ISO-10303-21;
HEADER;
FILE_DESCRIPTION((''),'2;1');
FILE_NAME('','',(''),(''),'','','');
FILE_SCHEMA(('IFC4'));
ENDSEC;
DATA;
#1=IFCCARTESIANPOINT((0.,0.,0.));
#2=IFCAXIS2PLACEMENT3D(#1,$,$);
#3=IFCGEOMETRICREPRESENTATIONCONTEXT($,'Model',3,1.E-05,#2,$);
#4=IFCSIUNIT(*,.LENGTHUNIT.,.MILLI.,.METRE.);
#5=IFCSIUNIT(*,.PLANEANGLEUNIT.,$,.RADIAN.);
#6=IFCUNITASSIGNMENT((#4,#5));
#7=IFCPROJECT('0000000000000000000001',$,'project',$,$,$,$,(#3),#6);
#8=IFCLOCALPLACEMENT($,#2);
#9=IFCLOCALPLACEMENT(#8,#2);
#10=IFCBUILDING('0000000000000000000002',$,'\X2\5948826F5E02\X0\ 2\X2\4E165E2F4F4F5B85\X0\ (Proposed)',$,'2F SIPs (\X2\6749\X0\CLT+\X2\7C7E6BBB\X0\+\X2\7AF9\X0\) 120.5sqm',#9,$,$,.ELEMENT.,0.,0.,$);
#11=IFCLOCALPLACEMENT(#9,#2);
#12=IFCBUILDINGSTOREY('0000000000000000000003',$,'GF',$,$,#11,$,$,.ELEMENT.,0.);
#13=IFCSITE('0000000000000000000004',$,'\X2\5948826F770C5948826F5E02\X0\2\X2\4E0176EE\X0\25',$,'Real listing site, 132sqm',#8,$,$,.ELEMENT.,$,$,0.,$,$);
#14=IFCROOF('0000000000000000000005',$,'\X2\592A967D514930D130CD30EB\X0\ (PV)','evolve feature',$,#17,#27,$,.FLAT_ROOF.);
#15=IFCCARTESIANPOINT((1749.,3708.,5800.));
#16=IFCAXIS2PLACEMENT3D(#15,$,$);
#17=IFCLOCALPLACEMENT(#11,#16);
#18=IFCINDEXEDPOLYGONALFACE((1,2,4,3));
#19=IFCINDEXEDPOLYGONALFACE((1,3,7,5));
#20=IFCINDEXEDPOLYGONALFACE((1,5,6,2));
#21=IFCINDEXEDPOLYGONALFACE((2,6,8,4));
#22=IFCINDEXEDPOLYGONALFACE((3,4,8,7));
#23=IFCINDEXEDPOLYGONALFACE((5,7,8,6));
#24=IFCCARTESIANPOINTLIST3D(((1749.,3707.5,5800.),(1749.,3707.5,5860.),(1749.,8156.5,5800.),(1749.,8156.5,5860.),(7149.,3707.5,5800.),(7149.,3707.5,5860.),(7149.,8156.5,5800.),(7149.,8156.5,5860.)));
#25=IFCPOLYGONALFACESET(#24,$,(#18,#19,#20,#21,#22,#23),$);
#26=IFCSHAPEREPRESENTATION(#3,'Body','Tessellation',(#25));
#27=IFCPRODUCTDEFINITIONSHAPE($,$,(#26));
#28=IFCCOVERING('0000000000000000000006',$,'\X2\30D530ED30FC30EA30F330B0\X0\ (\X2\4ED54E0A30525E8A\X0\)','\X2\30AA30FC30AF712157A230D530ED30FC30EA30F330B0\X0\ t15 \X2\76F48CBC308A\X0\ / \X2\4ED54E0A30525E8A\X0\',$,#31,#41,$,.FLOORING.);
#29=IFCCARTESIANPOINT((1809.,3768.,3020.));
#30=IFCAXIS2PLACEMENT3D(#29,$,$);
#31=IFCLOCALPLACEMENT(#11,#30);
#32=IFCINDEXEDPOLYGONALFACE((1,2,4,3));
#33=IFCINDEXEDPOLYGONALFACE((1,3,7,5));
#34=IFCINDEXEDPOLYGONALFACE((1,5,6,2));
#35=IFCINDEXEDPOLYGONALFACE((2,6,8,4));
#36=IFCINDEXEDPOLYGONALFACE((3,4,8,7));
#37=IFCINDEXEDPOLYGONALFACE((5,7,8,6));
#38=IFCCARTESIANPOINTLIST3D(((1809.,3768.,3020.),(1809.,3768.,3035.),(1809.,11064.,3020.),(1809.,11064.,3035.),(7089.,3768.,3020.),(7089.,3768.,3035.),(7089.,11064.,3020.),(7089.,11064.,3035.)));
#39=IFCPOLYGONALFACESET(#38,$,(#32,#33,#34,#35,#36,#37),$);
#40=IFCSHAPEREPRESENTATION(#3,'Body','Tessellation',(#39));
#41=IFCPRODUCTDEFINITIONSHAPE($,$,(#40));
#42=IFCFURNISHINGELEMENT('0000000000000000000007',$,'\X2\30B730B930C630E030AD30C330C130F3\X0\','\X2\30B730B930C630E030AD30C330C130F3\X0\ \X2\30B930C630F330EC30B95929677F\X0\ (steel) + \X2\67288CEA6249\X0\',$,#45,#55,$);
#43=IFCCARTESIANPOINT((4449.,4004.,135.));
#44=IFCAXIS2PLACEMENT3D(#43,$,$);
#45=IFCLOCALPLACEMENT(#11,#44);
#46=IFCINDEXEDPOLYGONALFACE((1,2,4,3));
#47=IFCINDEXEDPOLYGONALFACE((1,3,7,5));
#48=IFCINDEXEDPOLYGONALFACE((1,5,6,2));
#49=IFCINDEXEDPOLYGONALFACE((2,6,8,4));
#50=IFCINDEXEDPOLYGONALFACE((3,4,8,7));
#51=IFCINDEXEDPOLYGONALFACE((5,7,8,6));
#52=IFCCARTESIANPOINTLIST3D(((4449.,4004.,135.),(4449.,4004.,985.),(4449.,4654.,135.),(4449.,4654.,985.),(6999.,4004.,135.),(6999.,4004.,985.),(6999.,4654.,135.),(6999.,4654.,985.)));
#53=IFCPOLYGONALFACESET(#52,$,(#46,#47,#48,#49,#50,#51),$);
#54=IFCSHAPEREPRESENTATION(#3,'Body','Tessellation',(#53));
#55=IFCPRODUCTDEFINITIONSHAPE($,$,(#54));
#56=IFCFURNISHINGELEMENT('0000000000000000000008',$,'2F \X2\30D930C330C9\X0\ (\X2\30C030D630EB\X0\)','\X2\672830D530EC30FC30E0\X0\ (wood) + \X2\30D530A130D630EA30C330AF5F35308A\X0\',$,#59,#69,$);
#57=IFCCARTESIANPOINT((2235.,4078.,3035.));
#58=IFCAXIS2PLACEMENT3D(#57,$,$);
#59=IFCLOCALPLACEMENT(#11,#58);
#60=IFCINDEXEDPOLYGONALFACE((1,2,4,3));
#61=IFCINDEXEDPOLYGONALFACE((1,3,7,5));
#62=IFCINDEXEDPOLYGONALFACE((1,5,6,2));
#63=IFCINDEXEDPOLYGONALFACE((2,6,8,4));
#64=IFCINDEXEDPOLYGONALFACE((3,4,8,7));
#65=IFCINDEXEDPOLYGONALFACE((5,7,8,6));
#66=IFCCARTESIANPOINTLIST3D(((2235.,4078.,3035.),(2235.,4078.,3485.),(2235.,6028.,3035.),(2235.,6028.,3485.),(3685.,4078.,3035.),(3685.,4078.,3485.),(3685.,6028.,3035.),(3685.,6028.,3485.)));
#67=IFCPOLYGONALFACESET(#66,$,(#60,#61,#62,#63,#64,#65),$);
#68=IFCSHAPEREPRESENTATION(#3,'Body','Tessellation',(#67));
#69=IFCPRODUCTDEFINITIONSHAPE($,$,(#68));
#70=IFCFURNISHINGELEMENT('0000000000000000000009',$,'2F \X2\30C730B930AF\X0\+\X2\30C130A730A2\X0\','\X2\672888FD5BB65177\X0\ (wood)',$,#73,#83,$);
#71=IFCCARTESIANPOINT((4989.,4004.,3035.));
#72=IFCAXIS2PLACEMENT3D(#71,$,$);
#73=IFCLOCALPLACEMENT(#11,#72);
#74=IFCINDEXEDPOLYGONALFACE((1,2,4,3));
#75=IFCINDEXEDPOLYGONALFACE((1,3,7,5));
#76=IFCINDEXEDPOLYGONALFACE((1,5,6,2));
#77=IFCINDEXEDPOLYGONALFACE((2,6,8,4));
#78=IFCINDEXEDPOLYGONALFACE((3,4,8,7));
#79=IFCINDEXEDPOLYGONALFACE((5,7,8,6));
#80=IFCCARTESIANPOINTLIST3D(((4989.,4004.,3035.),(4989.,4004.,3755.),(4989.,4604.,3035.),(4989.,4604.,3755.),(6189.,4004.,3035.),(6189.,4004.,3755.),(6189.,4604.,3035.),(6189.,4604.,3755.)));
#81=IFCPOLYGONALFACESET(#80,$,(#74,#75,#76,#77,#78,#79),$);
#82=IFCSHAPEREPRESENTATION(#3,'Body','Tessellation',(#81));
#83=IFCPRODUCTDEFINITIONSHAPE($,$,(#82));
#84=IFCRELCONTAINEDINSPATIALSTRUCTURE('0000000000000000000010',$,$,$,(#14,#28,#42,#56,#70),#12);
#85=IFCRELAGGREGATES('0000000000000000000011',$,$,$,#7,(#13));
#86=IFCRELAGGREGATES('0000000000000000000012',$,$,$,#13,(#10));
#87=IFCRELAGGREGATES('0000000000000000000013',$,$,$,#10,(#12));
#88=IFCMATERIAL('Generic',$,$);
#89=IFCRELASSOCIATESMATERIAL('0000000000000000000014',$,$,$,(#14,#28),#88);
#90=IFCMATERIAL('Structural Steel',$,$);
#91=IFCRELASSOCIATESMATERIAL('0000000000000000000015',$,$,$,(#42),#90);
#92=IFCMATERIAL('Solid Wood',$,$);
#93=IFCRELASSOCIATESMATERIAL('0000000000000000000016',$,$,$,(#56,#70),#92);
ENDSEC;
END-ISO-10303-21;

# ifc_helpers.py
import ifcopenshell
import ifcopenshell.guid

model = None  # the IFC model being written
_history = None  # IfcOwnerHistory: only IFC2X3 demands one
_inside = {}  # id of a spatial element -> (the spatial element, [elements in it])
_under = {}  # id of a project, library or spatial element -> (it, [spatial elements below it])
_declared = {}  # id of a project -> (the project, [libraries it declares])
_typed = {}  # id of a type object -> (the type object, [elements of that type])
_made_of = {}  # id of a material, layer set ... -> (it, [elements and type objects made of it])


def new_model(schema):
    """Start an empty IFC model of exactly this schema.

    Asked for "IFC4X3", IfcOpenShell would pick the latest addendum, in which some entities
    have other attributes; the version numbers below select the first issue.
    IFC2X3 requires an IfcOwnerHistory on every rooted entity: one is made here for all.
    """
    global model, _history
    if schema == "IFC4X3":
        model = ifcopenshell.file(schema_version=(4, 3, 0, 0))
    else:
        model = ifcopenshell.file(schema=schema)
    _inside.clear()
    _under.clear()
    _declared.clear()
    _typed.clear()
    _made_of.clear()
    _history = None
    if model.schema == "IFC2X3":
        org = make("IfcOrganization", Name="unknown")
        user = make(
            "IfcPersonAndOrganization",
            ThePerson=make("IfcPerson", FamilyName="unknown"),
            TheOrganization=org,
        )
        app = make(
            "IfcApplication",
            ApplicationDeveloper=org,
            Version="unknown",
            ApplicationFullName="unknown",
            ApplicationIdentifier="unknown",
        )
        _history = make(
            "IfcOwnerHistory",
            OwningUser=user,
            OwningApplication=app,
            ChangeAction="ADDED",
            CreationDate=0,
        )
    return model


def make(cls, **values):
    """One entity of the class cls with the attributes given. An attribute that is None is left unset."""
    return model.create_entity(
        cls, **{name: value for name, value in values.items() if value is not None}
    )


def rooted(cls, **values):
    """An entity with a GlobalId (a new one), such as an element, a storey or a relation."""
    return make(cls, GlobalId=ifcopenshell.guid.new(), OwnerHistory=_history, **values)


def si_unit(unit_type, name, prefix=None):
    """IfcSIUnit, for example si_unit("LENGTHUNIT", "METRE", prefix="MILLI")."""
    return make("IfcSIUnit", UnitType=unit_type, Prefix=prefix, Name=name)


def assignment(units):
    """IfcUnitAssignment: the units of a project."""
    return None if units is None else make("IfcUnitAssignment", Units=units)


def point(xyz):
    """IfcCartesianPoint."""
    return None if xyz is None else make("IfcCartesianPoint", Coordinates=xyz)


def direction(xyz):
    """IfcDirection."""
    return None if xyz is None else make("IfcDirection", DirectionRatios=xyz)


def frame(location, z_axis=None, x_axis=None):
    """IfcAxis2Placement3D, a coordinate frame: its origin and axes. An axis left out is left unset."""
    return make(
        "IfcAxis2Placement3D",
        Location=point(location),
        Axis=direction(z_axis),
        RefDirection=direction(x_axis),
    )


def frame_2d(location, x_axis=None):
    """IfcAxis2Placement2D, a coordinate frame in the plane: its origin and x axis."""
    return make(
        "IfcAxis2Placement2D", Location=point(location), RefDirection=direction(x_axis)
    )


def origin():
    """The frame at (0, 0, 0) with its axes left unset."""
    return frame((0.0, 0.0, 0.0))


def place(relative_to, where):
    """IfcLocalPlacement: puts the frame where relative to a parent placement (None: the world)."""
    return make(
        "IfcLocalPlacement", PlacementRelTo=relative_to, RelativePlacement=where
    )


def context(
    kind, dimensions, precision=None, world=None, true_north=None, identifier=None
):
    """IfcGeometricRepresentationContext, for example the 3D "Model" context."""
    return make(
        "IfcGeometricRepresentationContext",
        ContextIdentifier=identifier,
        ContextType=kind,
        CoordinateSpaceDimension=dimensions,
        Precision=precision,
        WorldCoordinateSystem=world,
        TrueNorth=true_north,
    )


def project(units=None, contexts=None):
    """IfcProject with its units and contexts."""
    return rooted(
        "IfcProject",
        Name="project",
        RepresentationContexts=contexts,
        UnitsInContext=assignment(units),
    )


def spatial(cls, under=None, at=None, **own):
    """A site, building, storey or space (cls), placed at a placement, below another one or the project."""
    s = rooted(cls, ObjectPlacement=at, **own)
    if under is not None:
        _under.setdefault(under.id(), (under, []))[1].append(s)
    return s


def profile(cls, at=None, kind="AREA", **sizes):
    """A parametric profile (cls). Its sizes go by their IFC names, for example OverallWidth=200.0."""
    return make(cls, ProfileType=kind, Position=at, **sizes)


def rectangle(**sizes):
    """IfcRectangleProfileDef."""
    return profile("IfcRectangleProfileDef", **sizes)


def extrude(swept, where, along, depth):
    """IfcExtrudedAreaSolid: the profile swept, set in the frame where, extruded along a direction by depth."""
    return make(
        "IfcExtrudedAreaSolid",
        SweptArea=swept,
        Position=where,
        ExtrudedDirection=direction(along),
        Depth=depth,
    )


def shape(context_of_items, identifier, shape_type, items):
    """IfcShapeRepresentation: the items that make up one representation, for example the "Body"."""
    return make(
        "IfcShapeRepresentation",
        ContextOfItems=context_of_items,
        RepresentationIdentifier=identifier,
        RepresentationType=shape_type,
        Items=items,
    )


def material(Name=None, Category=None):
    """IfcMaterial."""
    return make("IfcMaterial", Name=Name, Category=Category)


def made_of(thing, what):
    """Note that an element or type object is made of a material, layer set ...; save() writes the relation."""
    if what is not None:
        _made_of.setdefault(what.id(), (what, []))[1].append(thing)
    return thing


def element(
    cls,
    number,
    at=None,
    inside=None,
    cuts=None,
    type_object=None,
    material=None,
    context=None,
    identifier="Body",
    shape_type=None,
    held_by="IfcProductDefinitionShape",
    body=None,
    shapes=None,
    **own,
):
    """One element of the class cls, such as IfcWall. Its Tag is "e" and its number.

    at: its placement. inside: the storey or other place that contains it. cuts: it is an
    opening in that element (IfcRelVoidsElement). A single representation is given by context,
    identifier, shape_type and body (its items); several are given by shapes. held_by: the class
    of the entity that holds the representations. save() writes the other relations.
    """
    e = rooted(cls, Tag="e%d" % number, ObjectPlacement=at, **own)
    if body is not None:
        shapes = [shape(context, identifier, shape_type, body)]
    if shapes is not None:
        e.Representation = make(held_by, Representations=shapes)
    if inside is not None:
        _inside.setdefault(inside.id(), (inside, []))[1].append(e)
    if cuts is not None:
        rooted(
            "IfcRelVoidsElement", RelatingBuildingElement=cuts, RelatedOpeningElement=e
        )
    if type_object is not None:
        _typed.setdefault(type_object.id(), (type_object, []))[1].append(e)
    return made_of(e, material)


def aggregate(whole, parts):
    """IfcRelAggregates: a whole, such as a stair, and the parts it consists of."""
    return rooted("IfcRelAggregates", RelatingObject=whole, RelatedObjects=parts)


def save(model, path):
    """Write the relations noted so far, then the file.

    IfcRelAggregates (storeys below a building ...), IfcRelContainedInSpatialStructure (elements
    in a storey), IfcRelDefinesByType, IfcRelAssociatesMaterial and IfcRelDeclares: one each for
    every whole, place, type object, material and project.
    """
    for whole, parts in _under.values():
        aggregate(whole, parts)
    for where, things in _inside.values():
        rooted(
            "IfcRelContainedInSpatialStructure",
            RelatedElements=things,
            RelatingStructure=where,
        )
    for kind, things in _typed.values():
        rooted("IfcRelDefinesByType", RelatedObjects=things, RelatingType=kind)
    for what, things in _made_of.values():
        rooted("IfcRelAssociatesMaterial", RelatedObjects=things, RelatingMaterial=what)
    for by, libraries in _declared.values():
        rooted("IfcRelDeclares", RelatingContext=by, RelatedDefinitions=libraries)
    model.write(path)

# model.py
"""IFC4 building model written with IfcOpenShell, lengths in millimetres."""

from ifc_helpers import new_model, si_unit, frame, frame_2d, origin, place, context, project, spatial, rectangle, extrude, material, element, save


model = new_model("IFC4")

# Units and contexts
model_context = context("Model", 3, precision=1e-05, world=origin())
ifc_project = project(units=[si_unit("LENGTHUNIT", "METRE", prefix="MILLI"), si_unit("PLANEANGLEUNIT", "RADIAN")], contexts=[model_context])

# Site, building, storey
site_placement = place(None, origin())
site = spatial("IfcSite", under=ifc_project, at=site_placement, Name="奈良県奈良市2丁目25", ObjectType="Real listing site, 132sqm", CompositionType="ELEMENT", RefElevation=0.0)
building_placement = place(site_placement, origin())
building = spatial("IfcBuilding", under=site, at=building_placement, Name="奈良市 2世帯住宅 (Proposed)", ObjectType="2F SIPs (杉CLT+籾殻+竹) 120.5sqm", CompositionType="ELEMENT", ElevationOfRefHeight=0.0, ElevationOfTerrain=0.0)
storey_placement = place(building_placement, origin())
storey = spatial("IfcBuildingStorey", under=building, at=storey_placement, Name="GF", CompositionType="ELEMENT", Elevation=0.0)

# Shared definitions
ifc_material_1 = material(Name="Solid Wood")

# Shared definitions
ifc_material_2 = material(Name="Generic")

# Roof
ifc_material_3 = material(Name="Structural Steel")
roof_1_placement = place(storey_placement, frame((1749.0, 3708.0, 5800.0)))
element("IfcRoof", 1, at=roof_1_placement, inside=storey, material=ifc_material_2, Name="太陽光パネル (PV)", Description="evolve feature", PredefinedType="FLAT_ROOF", context=model_context, shape_type="SweptSolid", body=[
    extrude(rectangle(XDim=5400.0, YDim=4449.0, at=frame_2d((2700.0, 2224.0))), frame((1749.0, 3708.0, 5800.0)), (0.0, 0.0, 1.0), 60.0),
])

# Covering
covering_placement = place(storey_placement, frame((1809.0, 3768.0, 3020.0)))
element("IfcCovering", 2, at=covering_placement, inside=storey, material=ifc_material_2, Name="フローリング (仕上げ床)", Description="オーク無垢フローリング t15 直貼り / 仕上げ床", PredefinedType="FLOORING", context=model_context, shape_type="SweptSolid", body=[
    extrude(rectangle(XDim=5280.0, YDim=7296.0, at=frame_2d((2640.0, 3648.0))), frame((1809.0, 3768.0, 3020.0)), (0.0, 0.0, 1.0), 15.0),
])

# Furnishing elements
furnishing_1_placement = place(storey_placement, frame((4449.0, 4004.0, 135.0)))
element("IfcFurnishingElement", 3, at=furnishing_1_placement, inside=storey, material=ifc_material_3, Name="システムキッチン", Description="システムキッチン ステンレス天板 (steel) + 木質扉", context=model_context, shape_type="SweptSolid", body=[
    extrude(rectangle(XDim=2550.0, YDim=650.0, at=frame_2d((1275.0, 325.0))), frame((4449.0, 4004.0, 135.0)), (0.0, 0.0, 1.0), 850.0),
])
furnishing_2_placement = place(storey_placement, frame((2235.0, 4078.0, 3035.0)))
element("IfcFurnishingElement", 4, at=furnishing_2_placement, inside=storey, material=ifc_material_1, Name="2F ベッド (ダブル)", Description="木フレーム (wood) + ファブリック張り", context=model_context, shape_type="SweptSolid", body=[
    extrude(rectangle(XDim=1450.0, YDim=1950.0, at=frame_2d((725.0, 975.0))), frame((2235.0, 4078.0, 3035.0)), (0.0, 0.0, 1.0), 450.0),
])
furnishing_3_placement = place(storey_placement, frame((4989.0, 4004.0, 3035.0)))
element("IfcFurnishingElement", 5, at=furnishing_3_placement, inside=storey, material=ifc_material_1, Name="2F デスク+チェア", Description="木製家具 (wood)", context=model_context, shape_type="SweptSolid", body=[
    extrude(rectangle(XDim=1200.0, YDim=600.0, at=frame_2d((600.0, 300.0))), frame((4989.0, 4004.0, 3035.0)), (0.0, 0.0, 1.0), 720.0),
])

save(model, "model.ifc")
